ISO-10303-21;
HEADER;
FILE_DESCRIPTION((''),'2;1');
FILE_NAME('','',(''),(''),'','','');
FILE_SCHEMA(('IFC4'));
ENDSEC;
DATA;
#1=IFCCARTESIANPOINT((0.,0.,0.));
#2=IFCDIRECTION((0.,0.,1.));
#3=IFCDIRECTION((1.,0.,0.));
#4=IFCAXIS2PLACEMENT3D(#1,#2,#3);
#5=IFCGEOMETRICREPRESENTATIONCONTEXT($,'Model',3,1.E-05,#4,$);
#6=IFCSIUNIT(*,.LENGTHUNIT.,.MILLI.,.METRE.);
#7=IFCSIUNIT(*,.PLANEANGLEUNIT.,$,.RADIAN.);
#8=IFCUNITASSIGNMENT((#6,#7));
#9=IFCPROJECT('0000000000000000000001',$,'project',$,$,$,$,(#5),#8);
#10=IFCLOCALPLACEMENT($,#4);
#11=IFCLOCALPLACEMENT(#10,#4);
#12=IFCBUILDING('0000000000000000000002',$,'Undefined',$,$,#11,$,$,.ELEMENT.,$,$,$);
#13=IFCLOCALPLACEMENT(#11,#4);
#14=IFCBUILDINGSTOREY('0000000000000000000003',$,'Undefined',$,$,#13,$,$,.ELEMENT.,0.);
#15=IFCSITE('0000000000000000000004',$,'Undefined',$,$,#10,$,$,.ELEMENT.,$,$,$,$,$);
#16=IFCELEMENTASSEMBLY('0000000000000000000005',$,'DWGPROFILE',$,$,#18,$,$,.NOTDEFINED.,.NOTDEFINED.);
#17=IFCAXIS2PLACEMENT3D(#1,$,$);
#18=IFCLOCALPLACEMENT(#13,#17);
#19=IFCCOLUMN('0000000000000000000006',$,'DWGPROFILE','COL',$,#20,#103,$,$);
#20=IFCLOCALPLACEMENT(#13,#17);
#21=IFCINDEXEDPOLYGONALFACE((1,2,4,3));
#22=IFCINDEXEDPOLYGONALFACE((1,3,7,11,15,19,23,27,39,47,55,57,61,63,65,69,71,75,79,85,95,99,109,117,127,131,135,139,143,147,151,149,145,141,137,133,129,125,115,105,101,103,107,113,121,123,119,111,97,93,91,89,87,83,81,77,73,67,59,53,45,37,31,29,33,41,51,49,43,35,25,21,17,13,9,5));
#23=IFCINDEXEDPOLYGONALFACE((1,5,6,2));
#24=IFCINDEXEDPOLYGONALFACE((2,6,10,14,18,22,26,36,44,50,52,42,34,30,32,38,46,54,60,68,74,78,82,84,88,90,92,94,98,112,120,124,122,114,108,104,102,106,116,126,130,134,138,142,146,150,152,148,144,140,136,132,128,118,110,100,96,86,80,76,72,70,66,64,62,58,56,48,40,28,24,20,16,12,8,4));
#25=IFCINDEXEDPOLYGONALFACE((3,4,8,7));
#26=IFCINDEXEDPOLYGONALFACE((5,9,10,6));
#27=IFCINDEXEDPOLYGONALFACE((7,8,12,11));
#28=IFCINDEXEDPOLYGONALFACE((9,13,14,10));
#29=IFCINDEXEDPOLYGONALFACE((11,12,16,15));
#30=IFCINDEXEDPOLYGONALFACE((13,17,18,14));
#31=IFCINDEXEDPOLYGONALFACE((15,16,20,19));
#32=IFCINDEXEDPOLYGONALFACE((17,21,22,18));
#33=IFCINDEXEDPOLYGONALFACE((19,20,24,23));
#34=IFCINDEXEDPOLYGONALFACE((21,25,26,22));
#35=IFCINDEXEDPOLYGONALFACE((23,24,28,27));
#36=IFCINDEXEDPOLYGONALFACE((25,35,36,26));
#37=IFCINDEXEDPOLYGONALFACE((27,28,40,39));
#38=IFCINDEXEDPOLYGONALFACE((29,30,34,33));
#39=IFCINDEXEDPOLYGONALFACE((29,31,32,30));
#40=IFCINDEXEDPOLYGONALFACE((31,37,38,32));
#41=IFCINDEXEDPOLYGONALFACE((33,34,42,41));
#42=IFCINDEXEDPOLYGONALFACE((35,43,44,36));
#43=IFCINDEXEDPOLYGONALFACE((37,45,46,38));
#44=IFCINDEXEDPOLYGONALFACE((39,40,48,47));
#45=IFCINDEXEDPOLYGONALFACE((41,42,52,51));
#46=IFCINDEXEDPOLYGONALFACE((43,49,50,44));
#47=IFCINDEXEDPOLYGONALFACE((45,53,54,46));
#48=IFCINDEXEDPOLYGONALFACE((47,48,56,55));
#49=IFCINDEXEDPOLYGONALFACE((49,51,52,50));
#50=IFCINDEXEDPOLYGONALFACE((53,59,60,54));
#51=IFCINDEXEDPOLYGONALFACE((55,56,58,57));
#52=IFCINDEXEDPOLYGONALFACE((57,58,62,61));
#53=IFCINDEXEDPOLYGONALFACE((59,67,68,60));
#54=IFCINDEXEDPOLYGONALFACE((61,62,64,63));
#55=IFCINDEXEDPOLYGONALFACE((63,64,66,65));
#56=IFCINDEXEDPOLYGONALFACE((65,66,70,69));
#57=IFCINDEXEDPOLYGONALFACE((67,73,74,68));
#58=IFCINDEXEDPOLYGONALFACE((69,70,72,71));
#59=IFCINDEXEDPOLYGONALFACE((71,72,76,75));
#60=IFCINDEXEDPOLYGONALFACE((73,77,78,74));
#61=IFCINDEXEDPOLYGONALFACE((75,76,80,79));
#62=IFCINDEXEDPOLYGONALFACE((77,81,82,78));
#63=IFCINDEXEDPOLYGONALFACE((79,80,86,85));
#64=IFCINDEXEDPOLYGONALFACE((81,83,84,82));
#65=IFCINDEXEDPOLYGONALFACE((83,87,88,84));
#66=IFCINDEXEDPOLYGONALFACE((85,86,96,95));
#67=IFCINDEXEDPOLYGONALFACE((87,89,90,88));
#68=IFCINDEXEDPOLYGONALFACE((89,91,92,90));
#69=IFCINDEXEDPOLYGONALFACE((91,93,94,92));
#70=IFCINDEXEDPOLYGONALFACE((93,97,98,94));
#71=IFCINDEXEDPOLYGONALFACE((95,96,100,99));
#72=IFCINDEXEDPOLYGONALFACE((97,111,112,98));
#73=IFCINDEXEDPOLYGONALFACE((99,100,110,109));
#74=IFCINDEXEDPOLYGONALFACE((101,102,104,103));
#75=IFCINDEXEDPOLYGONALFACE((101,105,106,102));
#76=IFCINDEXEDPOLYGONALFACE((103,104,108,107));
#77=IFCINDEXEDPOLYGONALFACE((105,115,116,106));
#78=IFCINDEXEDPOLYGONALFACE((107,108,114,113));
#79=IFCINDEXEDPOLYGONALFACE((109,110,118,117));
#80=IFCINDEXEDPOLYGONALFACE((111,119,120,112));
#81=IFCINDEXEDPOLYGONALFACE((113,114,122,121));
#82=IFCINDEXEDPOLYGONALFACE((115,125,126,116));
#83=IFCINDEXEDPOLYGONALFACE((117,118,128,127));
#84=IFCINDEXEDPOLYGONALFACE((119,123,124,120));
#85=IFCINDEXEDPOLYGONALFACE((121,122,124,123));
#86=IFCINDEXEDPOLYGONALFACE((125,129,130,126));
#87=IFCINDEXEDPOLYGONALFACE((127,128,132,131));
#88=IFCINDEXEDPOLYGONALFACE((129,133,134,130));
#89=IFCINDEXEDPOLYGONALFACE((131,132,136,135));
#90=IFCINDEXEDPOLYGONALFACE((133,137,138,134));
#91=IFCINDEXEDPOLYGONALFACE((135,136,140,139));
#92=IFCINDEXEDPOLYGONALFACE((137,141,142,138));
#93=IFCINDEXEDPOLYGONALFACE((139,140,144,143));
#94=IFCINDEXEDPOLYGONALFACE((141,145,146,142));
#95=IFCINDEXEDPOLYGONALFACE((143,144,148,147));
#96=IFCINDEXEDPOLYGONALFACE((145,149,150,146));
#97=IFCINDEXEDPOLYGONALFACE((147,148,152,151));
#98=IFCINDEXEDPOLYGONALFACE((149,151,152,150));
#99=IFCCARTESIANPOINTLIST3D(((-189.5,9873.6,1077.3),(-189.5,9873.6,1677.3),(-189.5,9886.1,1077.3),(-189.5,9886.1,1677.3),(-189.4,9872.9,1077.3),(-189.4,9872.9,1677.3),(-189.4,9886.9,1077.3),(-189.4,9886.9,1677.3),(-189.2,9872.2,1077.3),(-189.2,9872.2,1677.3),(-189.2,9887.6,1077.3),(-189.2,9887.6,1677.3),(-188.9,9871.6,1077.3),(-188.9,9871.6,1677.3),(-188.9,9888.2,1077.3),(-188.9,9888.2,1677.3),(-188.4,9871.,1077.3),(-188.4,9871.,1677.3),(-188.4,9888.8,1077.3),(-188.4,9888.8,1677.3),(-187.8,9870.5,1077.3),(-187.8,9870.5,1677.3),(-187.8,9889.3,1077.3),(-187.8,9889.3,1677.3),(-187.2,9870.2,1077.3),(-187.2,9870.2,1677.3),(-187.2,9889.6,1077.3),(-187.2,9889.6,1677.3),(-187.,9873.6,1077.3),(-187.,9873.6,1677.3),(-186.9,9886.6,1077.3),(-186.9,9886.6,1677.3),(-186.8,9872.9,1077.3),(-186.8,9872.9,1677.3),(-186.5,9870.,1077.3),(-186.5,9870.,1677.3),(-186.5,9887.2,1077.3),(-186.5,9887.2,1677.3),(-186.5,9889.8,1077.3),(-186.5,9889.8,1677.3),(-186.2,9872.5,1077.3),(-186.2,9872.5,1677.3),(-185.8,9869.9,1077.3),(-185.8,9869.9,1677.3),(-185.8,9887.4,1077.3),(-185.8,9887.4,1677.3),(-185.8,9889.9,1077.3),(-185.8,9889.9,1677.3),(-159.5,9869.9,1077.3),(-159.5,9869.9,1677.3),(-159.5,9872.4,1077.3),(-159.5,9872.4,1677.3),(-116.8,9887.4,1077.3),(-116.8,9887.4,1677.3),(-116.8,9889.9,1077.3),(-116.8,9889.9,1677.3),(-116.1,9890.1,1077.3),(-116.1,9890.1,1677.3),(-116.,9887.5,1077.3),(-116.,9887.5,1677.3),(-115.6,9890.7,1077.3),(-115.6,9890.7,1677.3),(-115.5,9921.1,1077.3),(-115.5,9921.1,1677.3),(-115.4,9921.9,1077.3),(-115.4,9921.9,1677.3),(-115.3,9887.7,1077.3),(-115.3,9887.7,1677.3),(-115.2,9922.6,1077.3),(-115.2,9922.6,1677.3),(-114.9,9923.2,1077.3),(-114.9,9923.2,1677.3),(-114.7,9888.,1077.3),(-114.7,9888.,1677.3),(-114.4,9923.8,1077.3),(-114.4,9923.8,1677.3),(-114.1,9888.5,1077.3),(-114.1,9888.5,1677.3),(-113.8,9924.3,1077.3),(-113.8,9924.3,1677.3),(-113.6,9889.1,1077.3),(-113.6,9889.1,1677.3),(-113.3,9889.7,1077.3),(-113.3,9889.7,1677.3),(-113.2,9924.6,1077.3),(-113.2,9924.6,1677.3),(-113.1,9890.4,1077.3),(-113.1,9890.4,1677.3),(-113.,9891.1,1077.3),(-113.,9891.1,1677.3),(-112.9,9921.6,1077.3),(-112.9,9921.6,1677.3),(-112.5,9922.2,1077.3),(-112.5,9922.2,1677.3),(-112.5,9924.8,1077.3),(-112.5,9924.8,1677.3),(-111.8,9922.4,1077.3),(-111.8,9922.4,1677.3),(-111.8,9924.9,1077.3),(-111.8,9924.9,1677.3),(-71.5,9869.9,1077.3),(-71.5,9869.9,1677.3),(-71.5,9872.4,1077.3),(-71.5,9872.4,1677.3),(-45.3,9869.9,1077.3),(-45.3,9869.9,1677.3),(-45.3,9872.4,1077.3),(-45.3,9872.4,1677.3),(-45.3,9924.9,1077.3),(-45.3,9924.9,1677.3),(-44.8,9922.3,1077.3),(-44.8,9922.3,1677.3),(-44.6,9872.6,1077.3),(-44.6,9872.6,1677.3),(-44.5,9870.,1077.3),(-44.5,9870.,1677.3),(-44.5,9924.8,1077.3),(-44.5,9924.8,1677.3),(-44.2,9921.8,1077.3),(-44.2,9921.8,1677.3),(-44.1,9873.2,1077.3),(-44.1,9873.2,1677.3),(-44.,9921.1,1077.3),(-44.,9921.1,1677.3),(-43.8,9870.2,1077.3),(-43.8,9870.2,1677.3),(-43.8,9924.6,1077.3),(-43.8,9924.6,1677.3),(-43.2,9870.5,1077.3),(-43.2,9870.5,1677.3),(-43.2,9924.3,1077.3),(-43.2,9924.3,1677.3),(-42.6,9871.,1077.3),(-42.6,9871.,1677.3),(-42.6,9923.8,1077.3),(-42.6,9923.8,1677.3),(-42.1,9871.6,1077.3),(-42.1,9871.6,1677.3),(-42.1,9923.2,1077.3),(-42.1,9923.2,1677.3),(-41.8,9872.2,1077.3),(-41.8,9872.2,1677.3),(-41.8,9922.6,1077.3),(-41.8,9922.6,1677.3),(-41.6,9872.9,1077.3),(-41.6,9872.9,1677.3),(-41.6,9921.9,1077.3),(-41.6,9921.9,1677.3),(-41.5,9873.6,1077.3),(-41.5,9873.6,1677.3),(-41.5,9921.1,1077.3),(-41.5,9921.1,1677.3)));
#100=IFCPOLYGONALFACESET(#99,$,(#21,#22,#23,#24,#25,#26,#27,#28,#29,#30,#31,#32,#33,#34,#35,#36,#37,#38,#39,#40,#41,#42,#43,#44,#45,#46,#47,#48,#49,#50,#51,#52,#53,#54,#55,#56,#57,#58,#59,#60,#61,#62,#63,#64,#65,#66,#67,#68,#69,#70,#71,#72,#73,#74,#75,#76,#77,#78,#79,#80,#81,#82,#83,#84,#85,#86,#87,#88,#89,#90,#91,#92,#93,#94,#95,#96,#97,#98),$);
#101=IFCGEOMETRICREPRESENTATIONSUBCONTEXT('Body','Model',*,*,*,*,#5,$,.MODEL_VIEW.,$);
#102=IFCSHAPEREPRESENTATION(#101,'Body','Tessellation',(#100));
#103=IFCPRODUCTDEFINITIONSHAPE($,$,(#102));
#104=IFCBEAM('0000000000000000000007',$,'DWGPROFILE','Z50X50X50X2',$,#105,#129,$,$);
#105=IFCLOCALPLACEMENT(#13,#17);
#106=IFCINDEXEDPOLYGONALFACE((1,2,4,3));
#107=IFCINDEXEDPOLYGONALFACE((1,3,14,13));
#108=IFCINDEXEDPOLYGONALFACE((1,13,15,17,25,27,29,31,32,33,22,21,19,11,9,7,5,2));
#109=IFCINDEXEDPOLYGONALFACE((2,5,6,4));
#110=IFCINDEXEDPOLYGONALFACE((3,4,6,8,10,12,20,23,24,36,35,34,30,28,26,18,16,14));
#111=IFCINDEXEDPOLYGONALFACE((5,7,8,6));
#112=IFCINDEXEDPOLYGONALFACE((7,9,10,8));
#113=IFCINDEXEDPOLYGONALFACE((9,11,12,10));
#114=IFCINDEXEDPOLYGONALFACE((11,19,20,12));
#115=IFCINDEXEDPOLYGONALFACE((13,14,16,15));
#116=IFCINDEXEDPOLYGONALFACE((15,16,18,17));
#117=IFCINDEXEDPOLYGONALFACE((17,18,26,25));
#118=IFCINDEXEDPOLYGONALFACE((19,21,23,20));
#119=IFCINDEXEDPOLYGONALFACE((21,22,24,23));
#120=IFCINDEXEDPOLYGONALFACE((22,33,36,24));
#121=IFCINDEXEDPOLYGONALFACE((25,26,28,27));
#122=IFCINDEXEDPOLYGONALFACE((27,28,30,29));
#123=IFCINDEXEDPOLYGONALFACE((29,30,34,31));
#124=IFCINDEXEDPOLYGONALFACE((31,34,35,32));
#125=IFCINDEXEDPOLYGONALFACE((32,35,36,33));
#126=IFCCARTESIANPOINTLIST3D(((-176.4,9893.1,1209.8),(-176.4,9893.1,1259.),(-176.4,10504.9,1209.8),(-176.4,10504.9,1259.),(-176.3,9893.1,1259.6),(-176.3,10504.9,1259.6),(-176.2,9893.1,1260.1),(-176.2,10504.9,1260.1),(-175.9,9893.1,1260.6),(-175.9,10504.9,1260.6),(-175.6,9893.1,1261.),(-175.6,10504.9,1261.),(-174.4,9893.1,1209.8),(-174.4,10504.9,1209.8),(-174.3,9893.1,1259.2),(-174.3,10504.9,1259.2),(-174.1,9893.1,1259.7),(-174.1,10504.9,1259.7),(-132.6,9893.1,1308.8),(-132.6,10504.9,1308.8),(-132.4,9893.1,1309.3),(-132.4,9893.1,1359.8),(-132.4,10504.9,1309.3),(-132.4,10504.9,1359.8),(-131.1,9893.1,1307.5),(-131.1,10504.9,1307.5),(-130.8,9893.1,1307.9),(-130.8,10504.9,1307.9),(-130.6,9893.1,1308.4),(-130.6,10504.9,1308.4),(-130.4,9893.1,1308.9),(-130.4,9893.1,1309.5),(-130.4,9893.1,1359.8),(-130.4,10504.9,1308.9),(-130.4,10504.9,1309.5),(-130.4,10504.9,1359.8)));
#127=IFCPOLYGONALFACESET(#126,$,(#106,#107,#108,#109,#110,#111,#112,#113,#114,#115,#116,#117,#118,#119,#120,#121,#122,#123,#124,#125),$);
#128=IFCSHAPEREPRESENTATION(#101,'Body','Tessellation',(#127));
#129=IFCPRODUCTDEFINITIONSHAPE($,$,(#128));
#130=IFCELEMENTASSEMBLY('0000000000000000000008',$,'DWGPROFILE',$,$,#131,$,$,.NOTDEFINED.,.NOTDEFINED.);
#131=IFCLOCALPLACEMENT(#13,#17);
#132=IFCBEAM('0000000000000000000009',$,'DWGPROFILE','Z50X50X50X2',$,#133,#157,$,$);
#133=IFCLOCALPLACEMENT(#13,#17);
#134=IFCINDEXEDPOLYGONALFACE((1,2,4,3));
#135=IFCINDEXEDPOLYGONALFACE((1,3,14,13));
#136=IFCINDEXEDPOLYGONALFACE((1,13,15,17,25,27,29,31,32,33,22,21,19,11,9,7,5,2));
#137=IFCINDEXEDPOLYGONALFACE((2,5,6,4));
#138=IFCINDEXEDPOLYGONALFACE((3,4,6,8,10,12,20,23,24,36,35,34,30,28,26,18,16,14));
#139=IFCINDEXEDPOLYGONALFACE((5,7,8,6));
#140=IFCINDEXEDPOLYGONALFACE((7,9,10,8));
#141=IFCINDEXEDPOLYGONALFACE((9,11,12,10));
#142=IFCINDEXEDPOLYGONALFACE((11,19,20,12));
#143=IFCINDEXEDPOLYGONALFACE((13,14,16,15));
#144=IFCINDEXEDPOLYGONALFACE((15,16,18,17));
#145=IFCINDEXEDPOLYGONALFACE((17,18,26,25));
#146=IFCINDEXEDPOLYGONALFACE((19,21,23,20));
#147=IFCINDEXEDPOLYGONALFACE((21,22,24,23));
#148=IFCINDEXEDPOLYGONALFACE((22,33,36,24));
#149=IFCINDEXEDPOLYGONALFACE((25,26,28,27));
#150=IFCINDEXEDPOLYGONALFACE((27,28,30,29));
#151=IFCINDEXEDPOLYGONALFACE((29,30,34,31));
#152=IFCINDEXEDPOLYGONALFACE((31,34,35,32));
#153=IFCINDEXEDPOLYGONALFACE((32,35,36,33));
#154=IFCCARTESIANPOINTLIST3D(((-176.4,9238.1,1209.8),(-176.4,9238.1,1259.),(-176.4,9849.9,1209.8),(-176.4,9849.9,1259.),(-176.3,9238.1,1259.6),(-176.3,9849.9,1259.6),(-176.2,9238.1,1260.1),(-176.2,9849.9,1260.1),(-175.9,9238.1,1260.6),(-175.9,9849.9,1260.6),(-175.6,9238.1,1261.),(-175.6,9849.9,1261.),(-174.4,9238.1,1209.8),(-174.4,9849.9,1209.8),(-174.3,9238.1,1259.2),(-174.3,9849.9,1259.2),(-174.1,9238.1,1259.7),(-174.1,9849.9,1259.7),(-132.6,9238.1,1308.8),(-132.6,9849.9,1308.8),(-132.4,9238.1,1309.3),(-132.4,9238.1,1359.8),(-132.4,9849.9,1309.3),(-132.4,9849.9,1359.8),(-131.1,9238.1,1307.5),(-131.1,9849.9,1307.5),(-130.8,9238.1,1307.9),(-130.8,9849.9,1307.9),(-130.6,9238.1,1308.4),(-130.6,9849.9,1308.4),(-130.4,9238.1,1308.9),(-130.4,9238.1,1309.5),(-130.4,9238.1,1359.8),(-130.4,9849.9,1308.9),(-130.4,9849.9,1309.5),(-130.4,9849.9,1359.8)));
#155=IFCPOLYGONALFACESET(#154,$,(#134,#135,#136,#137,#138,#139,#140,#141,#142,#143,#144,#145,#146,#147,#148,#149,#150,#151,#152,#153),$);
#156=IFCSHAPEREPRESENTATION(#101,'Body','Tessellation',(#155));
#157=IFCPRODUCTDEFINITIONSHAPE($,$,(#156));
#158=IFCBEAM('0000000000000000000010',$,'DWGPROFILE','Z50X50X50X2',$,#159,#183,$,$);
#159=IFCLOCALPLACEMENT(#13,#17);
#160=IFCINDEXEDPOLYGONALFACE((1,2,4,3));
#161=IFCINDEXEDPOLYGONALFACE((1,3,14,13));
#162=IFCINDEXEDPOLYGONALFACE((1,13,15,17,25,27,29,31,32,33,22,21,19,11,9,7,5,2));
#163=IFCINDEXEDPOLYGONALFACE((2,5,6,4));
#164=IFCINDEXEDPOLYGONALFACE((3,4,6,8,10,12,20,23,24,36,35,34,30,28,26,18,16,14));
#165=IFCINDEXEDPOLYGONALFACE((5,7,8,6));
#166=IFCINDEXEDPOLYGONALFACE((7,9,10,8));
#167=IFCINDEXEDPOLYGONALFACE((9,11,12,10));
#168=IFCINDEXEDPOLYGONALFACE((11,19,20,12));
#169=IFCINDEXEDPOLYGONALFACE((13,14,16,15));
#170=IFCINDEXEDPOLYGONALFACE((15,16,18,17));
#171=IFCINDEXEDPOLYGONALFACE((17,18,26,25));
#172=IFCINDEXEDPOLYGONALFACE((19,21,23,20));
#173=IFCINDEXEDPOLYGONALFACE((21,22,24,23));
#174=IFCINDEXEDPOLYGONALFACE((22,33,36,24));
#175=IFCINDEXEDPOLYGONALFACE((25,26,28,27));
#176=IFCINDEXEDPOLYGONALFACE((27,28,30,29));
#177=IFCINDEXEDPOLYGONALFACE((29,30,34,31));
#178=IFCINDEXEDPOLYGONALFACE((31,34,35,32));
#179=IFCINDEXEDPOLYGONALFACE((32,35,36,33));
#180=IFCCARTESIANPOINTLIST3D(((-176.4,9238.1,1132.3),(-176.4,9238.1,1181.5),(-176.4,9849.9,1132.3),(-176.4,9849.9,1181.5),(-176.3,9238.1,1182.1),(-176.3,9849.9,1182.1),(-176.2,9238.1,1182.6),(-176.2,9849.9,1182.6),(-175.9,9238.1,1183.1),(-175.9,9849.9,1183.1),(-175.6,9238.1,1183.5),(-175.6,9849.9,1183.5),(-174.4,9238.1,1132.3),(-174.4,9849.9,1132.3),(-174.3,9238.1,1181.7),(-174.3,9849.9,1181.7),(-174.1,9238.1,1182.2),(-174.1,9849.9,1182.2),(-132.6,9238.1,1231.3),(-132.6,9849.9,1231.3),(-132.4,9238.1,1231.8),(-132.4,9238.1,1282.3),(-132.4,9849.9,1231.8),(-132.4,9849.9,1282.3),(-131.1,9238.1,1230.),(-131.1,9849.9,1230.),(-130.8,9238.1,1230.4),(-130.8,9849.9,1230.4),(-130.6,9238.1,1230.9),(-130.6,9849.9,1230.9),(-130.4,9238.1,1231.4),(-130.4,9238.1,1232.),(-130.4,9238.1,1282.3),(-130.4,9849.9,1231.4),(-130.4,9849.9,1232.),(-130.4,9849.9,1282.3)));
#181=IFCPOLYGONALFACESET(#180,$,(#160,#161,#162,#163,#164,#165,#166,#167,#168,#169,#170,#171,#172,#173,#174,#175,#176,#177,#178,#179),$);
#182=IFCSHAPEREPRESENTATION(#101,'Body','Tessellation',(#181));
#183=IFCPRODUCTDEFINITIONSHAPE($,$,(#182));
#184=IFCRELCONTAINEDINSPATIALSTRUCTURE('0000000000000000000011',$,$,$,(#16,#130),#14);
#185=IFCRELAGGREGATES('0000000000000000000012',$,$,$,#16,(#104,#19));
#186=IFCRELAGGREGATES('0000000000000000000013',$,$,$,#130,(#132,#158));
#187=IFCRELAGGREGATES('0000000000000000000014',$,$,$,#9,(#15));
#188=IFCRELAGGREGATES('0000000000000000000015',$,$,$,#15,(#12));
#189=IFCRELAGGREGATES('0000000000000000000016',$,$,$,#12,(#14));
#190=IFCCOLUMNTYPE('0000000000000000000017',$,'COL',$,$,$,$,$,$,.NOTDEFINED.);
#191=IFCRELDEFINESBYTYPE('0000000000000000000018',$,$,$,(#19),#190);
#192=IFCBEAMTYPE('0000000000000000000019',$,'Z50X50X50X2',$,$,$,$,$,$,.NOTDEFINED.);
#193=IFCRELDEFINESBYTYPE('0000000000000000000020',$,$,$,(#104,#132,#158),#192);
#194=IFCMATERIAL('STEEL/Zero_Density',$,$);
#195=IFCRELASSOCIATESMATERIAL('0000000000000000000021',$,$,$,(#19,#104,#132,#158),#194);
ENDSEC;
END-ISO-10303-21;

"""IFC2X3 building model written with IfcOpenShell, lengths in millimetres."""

from ifc_helpers import new_model, si_unit, frame, origin_with_axes, place, context, subcontext, project, spatial, polyline, outline, extrude, material, type_object, element, aggregate, save


model = new_model("IFC2X3")

# Units and contexts
model_context = context("Model", 3, precision=1e-05, world=origin_with_axes())
body_context = subcontext(model_context, "Body", "Model", "MODEL_VIEW")
ifc_project = project(units=[si_unit("LENGTHUNIT", "METRE", prefix="MILLI"), si_unit("PLANEANGLEUNIT", "RADIAN")], contexts=[model_context])

# Site, building, storey
site_placement = place(None, origin_with_axes())
site = spatial("IfcSite", under=ifc_project, at=site_placement, Name="Undefined", CompositionType="ELEMENT")
building_placement = place(site_placement, origin_with_axes())
building = spatial("IfcBuilding", under=site, at=building_placement, Name="Undefined", CompositionType="ELEMENT")
storey_placement = place(building_placement, origin_with_axes())
storey = spatial("IfcBuildingStorey", under=building, at=storey_placement, Name="Undefined", CompositionType="ELEMENT", Elevation=0.0)

# Element assembly, column, beam
assembly_1_placement = place(storey_placement, origin_with_axes())
assembly_1 = element("IfcElementAssembly", 1, at=assembly_1_placement, inside=storey, Name="DWGPROFILE", AssemblyPlace="NOTDEFINED", PredefinedType="NOTDEFINED")
ifc_material_1 = material(Name="STEEL/Zero_Density")
column_type = type_object("IfcColumnType", Name="COL", PredefinedType="NOTDEFINED")
column_placement = place(assembly_1_placement, frame((-115.5, 9897.4, 1077.3), z_axis=(0.0, 0.0, 1.0), x_axis=(1.0, 0.0, 0.0)))
column = element("IfcColumn", 2, at=column_placement, type_object=column_type, material=ifc_material_1, Name="DWGPROFILE", Description="COL", context=body_context, shape_type="SweptSolid", body=[
    extrude(outline(polyline([(27.5, 70.2), (27.5, 3.8), (27.4, 3.0), (27.2, 2.3), (26.9, 1.7), (26.4, 1.1), (25.8, 0.6), (25.2, 0.3), (24.5, 0.1), (23.8, 0.0), (-6.7, -0.1), (-7.3, -0.6), (-7.5, -1.2), (-7.5, -70.2), (-7.6, -71.0), (-7.8, -71.7), (-8.1, -72.3), (-8.6, -72.9), (-9.2, -73.4), (-9.8, -73.7), (-10.5, -73.9), (-11.2, -74.0), (-23.8, -74.0), (-24.5, -73.9), (-25.2, -73.7), (-25.8, -73.4), (-26.4, -72.9), (-26.9, -72.3), (-27.2, -71.7), (-27.4, -71.0), (-27.5, -70.2), (-27.5, -44.0), (-25.0, -44.0), (-24.9, -70.7), (-24.4, -71.3), (-23.8, -71.5), (-10.8, -71.4), (-10.2, -70.9), (-10.0, -70.2), (-10.0, -1.2), (-9.9, -0.5), (-9.7, 0.2), (-9.4, 0.8), (-8.9, 1.4), (-8.3, 1.9), (-7.7, 2.2), (-7.0, 2.4), (-6.2, 2.5), (24.2, 2.6), (24.8, 3.1), (25.0, 3.8), (24.9, 70.7), (24.4, 71.3), (23.8, 71.5), (-24.2, 71.4), (-24.8, 70.9), (-25.0, 70.2), (-25.0, 44.0), (-27.5, 44.0), (-27.5, 70.2), (-27.4, 71.0), (-27.2, 71.7), (-26.9, 72.3), (-26.4, 72.9), (-25.8, 73.4), (-25.2, 73.7), (-24.5, 73.9), (-23.8, 74.0), (23.8, 74.0), (24.5, 73.9), (25.2, 73.7), (25.8, 73.4), (26.4, 72.9), (26.9, 72.3), (27.2, 71.7), (27.4, 71.0), (27.5, 70.2)])), frame((0.0, 0.0, 600.0), z_axis=(0.0, 0.000001, -1.0), x_axis=(0.0, 1.0, 0.0)), (0.0, 0.0, 1.0), 600.0),
])
beam_type_1 = type_object("IfcBeamType", Name="Z50X50X50X2", PredefinedType="NOTDEFINED")
beam_1_placement = place(assembly_1_placement, frame((-153.4, 10504.9, 1284.8), z_axis=(0.0, 0.0, 1.0), x_axis=(0.0, -1.0, 0.0)))
beam_1 = element("IfcBeam", 3, at=beam_1_placement, type_object=beam_type_1, material=ifc_material_1, Name="DWGPROFILE", Description="Z50X50X50X2", context=body_context, shape_type="SweptSolid", body=[
    extrude(outline(polyline([(-22.9, 24.1), (-23.0, 24.7), (-23.0, 75.0), (-21.0, 75.0), (-21.0, 24.5), (-20.7, 24.0), (22.2, -23.8), (22.6, -24.2), (22.8, -24.7), (22.9, -25.2), (23.0, -25.8), (23.0, -75.0), (21.0, -75.0), (21.0, -25.6), (20.7, -25.1), (-22.2, 22.6), (-22.6, 23.1), (-22.8, 23.6), (-22.9, 24.1)])), frame((611.8, 0.0, 0.0), z_axis=(-1.0, 0.0, 0.0), x_axis=(0.0, -1.0, 0.0)), (0.0, 0.0, 1.0), 611.8),
])

# Element assembly, beams
assembly_2_placement = place(storey_placement, origin_with_axes())
assembly_2 = element("IfcElementAssembly", 4, at=assembly_2_placement, inside=storey, Name="DWGPROFILE", AssemblyPlace="NOTDEFINED", PredefinedType="NOTDEFINED")
beam_2_placement = place(assembly_2_placement, frame((-153.4, 9849.9, 1284.8), z_axis=(0.0, 0.0, 1.0), x_axis=(0.0, -1.0, 0.0)))
beam_2 = element("IfcBeam", 5, at=beam_2_placement, type_object=beam_type_1, material=ifc_material_1, Name="DWGPROFILE", Description="Z50X50X50X2", context=body_context, shape_type="SweptSolid", body=[
    extrude(outline(polyline([(-22.9, 24.1), (-23.0, 24.7), (-23.0, 75.0), (-21.0, 75.0), (-21.0, 24.5), (-20.7, 24.0), (22.2, -23.8), (22.6, -24.2), (22.8, -24.7), (22.9, -25.2), (23.0, -25.8), (23.0, -75.0), (21.0, -75.0), (21.0, -25.6), (20.7, -25.1), (-22.2, 22.6), (-22.6, 23.1), (-22.8, 23.6), (-22.9, 24.1)])), frame((611.8, 0.0, 0.0), z_axis=(-1.0, 0.0, 0.0), x_axis=(0.0, -1.0, 0.0)), (0.0, 0.0, 1.0), 611.8),
])
beam_3_placement = place(assembly_2_placement, frame((-153.4, 9849.9, 1207.3), z_axis=(0.0, 0.0, 1.0), x_axis=(0.0, -1.0, 0.0)))
beam_3 = element("IfcBeam", 6, at=beam_3_placement, type_object=beam_type_1, material=ifc_material_1, Name="DWGPROFILE", Description="Z50X50X50X2", context=body_context, shape_type="SweptSolid", body=[
    extrude(outline(polyline([(-22.9, 24.1), (-23.0, 24.7), (-23.0, 75.0), (-21.0, 75.0), (-21.0, 24.5), (-20.7, 24.0), (22.2, -23.8), (22.6, -24.2), (22.8, -24.7), (22.9, -25.2), (23.0, -25.8), (23.0, -75.0), (21.0, -75.0), (21.0, -25.6), (20.7, -25.1), (-22.2, 22.6), (-22.6, 23.1), (-22.8, 23.6), (-22.9, 24.1)])), frame((611.8, 0.0, 0.0), z_axis=(-1.0, 0.0, 0.0), x_axis=(0.0, -1.0, 0.0)), (0.0, 0.0, 1.0), 611.8),
])

aggregate(assembly_1, [beam_1, column])
aggregate(assembly_2, [beam_2, beam_3])

save(model, "model.ifc")
